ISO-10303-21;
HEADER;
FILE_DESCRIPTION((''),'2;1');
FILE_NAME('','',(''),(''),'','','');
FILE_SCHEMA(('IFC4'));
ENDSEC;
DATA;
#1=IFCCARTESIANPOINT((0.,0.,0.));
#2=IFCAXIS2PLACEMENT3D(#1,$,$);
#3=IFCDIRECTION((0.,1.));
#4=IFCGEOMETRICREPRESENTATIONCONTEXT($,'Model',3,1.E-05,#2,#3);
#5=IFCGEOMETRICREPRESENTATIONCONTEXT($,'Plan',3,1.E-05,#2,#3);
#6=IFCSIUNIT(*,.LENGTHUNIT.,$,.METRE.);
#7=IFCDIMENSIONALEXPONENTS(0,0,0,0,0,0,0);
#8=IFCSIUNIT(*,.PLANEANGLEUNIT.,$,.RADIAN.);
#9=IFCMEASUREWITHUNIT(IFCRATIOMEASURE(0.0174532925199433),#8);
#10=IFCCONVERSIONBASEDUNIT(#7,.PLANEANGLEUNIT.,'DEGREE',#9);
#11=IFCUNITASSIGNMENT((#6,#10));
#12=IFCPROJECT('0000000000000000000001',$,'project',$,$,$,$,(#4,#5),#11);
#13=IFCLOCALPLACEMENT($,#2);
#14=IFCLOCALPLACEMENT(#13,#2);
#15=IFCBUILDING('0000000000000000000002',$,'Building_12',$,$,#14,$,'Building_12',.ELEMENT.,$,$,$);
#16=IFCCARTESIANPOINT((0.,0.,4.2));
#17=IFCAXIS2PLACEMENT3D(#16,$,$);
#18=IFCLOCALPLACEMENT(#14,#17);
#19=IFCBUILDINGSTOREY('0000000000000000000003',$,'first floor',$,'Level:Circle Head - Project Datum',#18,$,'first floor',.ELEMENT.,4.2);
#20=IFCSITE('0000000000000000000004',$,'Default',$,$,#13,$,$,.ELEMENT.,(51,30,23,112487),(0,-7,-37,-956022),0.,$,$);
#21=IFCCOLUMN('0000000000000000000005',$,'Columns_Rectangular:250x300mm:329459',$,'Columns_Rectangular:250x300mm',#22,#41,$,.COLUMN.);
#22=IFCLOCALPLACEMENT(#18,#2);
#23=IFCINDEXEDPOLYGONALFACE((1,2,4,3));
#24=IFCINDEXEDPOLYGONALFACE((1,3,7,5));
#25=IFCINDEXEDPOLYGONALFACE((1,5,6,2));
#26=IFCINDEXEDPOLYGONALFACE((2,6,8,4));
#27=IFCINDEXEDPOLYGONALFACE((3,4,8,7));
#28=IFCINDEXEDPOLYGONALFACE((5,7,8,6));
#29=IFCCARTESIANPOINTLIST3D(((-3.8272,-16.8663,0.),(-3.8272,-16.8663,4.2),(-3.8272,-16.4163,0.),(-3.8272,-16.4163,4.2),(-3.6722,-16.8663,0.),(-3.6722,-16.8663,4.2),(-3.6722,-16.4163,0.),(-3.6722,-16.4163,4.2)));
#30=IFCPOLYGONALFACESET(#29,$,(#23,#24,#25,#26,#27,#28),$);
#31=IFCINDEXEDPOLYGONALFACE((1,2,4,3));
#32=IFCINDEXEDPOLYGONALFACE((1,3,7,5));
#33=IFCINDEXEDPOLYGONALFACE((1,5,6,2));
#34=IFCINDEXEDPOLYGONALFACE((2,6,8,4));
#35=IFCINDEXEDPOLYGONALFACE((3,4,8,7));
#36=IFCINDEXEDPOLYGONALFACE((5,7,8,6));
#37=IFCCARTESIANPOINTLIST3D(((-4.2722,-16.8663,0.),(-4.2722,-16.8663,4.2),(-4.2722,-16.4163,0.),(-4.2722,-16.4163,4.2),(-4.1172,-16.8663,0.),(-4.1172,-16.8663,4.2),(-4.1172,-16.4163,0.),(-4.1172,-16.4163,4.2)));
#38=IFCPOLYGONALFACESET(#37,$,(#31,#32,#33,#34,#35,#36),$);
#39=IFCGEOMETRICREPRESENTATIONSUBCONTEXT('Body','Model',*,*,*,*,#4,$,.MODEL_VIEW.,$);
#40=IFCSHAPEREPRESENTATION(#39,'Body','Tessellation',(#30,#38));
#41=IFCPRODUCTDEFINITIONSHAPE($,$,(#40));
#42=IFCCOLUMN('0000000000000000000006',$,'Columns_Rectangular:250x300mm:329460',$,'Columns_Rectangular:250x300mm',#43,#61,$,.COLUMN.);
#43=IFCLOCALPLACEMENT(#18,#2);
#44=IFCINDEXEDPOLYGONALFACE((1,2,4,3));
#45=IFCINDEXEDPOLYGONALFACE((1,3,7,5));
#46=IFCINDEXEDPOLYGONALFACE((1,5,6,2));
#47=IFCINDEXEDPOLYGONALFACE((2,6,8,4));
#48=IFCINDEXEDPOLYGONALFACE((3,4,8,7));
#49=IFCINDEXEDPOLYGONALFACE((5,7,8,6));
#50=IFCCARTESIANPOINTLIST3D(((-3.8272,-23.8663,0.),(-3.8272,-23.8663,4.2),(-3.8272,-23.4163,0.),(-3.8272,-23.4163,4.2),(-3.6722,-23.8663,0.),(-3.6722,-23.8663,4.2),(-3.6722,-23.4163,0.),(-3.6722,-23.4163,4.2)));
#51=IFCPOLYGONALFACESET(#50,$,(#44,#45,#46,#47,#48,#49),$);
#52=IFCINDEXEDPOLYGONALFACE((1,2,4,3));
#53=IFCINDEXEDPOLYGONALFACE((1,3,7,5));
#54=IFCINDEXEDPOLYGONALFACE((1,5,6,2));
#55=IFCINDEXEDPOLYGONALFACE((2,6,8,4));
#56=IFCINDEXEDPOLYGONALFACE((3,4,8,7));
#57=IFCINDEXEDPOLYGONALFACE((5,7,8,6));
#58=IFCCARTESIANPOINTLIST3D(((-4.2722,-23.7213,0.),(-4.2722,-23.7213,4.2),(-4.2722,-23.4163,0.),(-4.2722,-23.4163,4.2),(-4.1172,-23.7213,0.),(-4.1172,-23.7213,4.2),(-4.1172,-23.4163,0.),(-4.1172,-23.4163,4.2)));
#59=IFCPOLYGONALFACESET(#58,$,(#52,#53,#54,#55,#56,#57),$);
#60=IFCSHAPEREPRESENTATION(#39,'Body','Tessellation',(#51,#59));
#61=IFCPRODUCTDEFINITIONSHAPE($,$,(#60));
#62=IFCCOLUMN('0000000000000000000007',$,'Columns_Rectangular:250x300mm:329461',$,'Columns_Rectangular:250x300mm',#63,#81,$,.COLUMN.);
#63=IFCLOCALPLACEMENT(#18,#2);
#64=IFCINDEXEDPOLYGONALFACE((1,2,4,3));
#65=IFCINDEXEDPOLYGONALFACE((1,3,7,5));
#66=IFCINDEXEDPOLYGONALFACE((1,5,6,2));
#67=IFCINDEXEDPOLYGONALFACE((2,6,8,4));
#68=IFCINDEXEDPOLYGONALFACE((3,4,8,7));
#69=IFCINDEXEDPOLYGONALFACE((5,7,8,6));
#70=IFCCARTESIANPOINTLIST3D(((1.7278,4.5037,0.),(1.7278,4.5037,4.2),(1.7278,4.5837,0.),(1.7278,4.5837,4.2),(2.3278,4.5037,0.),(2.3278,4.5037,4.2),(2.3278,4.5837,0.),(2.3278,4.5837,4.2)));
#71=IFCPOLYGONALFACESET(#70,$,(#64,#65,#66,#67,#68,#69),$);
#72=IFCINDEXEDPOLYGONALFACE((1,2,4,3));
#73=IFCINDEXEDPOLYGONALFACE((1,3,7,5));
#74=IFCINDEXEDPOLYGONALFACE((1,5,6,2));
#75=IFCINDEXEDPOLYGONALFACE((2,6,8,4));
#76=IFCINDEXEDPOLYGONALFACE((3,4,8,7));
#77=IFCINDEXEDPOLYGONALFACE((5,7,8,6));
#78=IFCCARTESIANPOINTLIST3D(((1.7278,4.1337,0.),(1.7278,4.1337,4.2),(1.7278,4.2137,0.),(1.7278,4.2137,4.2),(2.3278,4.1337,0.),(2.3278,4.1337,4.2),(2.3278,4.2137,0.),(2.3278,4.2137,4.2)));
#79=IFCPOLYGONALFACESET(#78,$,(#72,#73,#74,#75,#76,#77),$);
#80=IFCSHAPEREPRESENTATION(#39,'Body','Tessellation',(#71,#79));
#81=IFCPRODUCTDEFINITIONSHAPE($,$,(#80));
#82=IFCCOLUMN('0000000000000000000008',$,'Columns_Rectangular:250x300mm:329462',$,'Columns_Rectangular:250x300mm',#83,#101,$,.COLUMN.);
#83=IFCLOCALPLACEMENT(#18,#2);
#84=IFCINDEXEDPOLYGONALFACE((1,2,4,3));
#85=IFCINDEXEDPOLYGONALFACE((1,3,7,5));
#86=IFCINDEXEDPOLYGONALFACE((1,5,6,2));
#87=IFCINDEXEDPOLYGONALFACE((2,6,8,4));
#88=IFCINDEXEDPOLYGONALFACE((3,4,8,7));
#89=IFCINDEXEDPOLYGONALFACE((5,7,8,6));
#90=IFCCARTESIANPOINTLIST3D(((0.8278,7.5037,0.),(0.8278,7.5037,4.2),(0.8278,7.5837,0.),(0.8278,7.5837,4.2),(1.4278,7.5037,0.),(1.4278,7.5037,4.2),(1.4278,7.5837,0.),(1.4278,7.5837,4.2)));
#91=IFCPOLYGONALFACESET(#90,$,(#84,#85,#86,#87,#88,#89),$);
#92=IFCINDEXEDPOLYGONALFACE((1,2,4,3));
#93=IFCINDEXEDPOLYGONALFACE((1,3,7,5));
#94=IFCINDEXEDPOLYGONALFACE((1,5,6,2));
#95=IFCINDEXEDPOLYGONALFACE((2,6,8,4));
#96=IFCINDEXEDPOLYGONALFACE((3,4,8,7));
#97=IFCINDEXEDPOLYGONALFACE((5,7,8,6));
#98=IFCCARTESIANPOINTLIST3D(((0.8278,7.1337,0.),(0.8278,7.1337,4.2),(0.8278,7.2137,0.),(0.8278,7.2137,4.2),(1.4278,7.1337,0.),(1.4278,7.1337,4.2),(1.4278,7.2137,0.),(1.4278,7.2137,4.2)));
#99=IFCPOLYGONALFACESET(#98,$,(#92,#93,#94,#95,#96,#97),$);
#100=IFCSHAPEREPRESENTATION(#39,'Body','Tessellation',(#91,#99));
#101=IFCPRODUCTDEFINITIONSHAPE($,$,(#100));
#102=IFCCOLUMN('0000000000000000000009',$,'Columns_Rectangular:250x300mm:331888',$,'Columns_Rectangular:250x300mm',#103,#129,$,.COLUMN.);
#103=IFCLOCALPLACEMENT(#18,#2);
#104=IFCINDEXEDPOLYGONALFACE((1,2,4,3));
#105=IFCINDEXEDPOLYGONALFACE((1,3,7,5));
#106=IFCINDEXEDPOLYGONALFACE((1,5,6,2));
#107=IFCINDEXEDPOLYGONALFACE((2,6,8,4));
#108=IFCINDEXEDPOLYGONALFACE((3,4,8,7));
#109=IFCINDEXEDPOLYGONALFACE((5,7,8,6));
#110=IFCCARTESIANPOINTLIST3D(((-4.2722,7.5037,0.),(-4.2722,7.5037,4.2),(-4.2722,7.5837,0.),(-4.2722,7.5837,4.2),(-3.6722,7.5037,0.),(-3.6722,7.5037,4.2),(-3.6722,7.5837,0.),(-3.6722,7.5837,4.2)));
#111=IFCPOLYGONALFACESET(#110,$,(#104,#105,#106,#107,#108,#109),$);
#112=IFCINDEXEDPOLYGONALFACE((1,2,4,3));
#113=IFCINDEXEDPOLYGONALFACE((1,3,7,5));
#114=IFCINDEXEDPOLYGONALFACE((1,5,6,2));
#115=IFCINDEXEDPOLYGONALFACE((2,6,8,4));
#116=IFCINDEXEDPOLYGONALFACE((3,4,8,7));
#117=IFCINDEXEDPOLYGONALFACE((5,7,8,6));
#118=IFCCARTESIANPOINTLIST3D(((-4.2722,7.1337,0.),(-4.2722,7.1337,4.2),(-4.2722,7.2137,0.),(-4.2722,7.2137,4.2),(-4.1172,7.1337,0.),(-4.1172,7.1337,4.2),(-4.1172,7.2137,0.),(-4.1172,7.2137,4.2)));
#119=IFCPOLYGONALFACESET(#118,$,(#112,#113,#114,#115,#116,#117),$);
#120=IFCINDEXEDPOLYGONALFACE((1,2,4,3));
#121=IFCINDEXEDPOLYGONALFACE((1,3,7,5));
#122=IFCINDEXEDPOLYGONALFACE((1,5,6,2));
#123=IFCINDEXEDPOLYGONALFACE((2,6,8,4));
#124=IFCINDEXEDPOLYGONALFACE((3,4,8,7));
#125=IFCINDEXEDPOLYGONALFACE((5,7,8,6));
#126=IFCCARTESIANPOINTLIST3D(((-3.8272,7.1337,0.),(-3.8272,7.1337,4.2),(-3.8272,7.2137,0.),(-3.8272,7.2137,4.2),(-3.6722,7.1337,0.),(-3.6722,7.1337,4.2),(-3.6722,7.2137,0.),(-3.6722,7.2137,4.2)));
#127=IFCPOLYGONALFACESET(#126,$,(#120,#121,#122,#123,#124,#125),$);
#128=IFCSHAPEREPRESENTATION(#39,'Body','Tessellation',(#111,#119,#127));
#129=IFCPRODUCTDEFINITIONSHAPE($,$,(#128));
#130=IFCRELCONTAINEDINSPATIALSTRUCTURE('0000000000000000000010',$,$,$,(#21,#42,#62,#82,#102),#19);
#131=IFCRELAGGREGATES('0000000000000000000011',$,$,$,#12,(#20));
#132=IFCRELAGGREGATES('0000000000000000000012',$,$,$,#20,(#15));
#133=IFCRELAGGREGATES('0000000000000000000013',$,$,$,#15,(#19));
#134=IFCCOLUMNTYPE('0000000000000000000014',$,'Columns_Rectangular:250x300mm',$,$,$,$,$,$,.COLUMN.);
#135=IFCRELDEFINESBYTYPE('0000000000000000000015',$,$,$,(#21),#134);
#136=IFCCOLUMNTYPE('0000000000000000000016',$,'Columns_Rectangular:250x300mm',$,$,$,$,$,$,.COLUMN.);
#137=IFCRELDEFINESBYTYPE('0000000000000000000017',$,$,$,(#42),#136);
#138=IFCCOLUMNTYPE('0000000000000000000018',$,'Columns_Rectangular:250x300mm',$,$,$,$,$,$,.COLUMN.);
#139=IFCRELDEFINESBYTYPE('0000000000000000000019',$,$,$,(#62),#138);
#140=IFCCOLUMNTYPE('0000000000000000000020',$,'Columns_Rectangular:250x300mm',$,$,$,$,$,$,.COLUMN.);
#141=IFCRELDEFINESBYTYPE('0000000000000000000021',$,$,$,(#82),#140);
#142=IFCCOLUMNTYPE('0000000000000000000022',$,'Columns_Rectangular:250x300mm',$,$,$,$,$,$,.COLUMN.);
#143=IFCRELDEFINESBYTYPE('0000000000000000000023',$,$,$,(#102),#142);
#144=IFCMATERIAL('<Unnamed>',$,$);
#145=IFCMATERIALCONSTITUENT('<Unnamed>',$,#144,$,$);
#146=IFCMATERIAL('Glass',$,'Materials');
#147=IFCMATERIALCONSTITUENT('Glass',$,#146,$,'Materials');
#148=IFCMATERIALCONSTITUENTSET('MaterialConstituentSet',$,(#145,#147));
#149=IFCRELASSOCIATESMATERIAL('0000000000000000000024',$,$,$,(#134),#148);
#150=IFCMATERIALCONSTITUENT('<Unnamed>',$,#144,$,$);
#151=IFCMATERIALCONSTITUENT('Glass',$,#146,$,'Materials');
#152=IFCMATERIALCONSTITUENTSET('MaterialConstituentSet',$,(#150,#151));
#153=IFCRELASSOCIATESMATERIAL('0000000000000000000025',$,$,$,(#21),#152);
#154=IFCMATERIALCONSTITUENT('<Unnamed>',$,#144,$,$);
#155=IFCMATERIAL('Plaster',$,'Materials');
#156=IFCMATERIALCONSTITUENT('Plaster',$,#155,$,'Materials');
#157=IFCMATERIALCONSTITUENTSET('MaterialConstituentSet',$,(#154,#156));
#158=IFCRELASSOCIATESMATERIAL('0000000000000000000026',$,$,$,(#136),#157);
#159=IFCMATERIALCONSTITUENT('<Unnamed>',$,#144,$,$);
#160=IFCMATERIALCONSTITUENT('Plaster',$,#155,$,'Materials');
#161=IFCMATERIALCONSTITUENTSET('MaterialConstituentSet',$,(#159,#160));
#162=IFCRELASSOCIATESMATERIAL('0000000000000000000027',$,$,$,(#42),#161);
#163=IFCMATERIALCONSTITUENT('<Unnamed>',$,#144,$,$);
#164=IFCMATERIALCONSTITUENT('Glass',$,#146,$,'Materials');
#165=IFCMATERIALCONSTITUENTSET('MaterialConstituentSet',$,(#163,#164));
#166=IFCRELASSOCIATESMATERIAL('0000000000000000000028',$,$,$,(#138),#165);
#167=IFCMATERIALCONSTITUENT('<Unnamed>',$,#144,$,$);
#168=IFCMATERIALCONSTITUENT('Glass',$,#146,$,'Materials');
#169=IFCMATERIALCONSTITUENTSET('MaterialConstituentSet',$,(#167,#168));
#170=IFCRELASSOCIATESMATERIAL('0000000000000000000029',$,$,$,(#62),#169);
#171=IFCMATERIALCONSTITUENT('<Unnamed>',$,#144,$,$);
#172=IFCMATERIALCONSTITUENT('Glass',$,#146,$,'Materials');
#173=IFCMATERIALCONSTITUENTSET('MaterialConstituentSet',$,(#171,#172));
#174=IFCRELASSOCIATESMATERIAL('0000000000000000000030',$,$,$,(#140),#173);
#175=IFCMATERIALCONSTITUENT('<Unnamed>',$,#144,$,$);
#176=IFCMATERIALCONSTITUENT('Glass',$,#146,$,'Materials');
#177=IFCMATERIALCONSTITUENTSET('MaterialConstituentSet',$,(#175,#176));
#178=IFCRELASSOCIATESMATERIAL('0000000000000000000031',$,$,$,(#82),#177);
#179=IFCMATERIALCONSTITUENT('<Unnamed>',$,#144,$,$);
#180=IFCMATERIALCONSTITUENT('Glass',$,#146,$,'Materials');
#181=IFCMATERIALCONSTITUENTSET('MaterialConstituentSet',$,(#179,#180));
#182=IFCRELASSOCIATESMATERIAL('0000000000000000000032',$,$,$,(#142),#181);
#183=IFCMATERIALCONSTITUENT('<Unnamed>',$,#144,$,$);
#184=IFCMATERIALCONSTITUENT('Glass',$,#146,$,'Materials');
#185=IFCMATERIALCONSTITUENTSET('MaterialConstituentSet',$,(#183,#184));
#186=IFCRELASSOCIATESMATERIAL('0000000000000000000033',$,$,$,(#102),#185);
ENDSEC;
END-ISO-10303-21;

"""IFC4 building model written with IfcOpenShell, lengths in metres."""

from ifc_helpers import new_model, entity, si_unit, converted_unit, direction, frame, origin, place, context, subcontext, project, spatial, indexed_curve, outline, extrude, source, transform, mapped, material, constituent, constituent_set, type_object, type_shapes, element, save


model = new_model("IFC4")

# Units and contexts
model_context = context("Model", 3, precision=1e-05, world=origin(), true_north=direction((0.0, 1.0)))
plan_context = context("Plan", 3, precision=1e-05, world=origin(), true_north=direction((0.0, 1.0)))
body_context = subcontext(model_context, "Body", "Model", "MODEL_VIEW")
ifc_project = project(units=[si_unit("LENGTHUNIT", "METRE"), converted_unit("PLANEANGLEUNIT", "DEGREE", entity("IfcRatioMeasure", 0.0174532925199433), si_unit("PLANEANGLEUNIT", "RADIAN"), dimensions=[0, 0, 0, 0, 0, 0, 0])], contexts=[model_context, plan_context])

# Site, building, storey
site_placement = place(None, origin())
site = spatial("IfcSite", under=ifc_project, at=site_placement, Name="Default", CompositionType="ELEMENT", RefLatitude=(51, 30, 23, 112487), RefLongitude=(0, -7, -37, -956022), RefElevation=0.0)
building_placement = place(site_placement, origin())
building = spatial("IfcBuilding", under=site, at=building_placement, Name="Building_12", LongName="Building_12", CompositionType="ELEMENT")
storey_placement = place(building_placement, frame((0.0, 0.0, 4.2)))
storey = spatial("IfcBuildingStorey", under=building, at=storey_placement, Name="first floor", ObjectType="Level:Circle Head - Project Datum", LongName="first floor", CompositionType="ELEMENT", Elevation=4.2)

# Columns
ifc_material_1 = material(Name="<Unnamed>")
ifc_material_2 = material(Name="Plaster", Category="Materials")
ifc_material_3 = material(Name="Glass", Category="Materials")
ifc_constituent_1 = constituent(ifc_material_1, Name="<Unnamed>")
ifc_constituent_2 = constituent(ifc_material_3, Name="Glass", Category="Materials")
ifc_constituent_set_1 = constituent_set(constituents=[ifc_constituent_1, ifc_constituent_2], Name="MaterialConstituentSet")
ifc_constituent_3 = constituent(ifc_material_1, Name="<Unnamed>")
ifc_constituent_4 = constituent(ifc_material_3, Name="Glass", Category="Materials")
ifc_constituent_set_2 = constituent_set(constituents=[ifc_constituent_3, ifc_constituent_4], Name="MaterialConstituentSet")
column_type_1 = type_object("IfcColumnType", Name="Columns_Rectangular:250x300mm", PredefinedType="COLUMN", material=ifc_constituent_set_2)
shared_shape_1 = source(origin(), body_context, "Body", "SweptSolid", [
    extrude(outline(indexed_curve([(-0.225, -0.0775), (0.225, -0.0775), (0.225, 0.0775), (-0.225, 0.0775), (-0.225, -0.0775)], self_intersect=False)), frame((-3.7497, -16.6413, 4.2), z_axis=(0.0, 0.0, 1.0), x_axis=(0.0, -1.0, 0.0)), (0.0, 0.0, 1.0), 4.2),
    extrude(outline(indexed_curve([(-0.225, -0.0775), (0.225, -0.0775), (0.225, 0.0775), (-0.225, 0.0775), (-0.225, -0.0775)], self_intersect=False)), frame((-4.1947, -16.6413, 4.2), z_axis=(0.0, 0.0, 1.0), x_axis=(0.0, -1.0, 0.0)), (0.0, 0.0, 1.0), 4.2),
])
type_shapes(column_type_1, [shared_shape_1])
column_1_placement = place(storey_placement, frame((0.0, 0.0, -4.2)))
element("IfcColumn", 1, at=column_1_placement, inside=storey, type_object=column_type_1, material=ifc_constituent_set_1, Name="Columns_Rectangular:250x300mm:329459", ObjectType="Columns_Rectangular:250x300mm", PredefinedType="COLUMN", context=body_context, shape_type="MappedRepresentation", body=[
    mapped(shared_shape_1, transform((0.0, 0.0, 0.0), scale=1.0)),
])
ifc_constituent_5 = constituent(ifc_material_1, Name="<Unnamed>")
ifc_constituent_6 = constituent(ifc_material_2, Name="Plaster", Category="Materials")
ifc_constituent_set_3 = constituent_set(constituents=[ifc_constituent_5, ifc_constituent_6], Name="MaterialConstituentSet")
ifc_constituent_7 = constituent(ifc_material_1, Name="<Unnamed>")
ifc_constituent_8 = constituent(ifc_material_2, Name="Plaster", Category="Materials")
ifc_constituent_set_4 = constituent_set(constituents=[ifc_constituent_7, ifc_constituent_8], Name="MaterialConstituentSet")
column_type_2 = type_object("IfcColumnType", Name="Columns_Rectangular:250x300mm", PredefinedType="COLUMN", material=ifc_constituent_set_4)
shared_shape_2 = source(origin(), body_context, "Body", "SweptSolid", [
    extrude(outline(indexed_curve([(-0.225, -0.0775), (0.225, -0.0775), (0.225, 0.0775), (-0.225, 0.0775), (-0.225, -0.0775)], self_intersect=False)), frame((-3.7497, -23.6413, 4.2), z_axis=(0.0, 0.0, 1.0), x_axis=(0.0, -1.0, 0.0)), (0.0, 0.0, 1.0), 4.2),
    extrude(outline(indexed_curve([(-0.1525, -0.0775), (0.1525, -0.0775), (0.1525, 0.0775), (-0.1525, 0.0775), (-0.1525, -0.0775)], self_intersect=False)), frame((-4.1947, -23.5688, 4.2), z_axis=(0.0, 0.0, 1.0), x_axis=(0.0, -1.0, 0.0)), (0.0, 0.0, 1.0), 4.2),
])
type_shapes(column_type_2, [shared_shape_2])
column_2_placement = place(storey_placement, frame((0.0, 0.0, -4.2)))
element("IfcColumn", 2, at=column_2_placement, inside=storey, type_object=column_type_2, material=ifc_constituent_set_3, Name="Columns_Rectangular:250x300mm:329460", ObjectType="Columns_Rectangular:250x300mm", PredefinedType="COLUMN", context=body_context, shape_type="MappedRepresentation", body=[
    mapped(shared_shape_2, transform((0.0, 0.0, 0.0), scale=1.0)),
])
ifc_constituent_9 = constituent(ifc_material_1, Name="<Unnamed>")
ifc_constituent_10 = constituent(ifc_material_3, Name="Glass", Category="Materials")
ifc_constituent_set_5 = constituent_set(constituents=[ifc_constituent_9, ifc_constituent_10], Name="MaterialConstituentSet")
ifc_constituent_11 = constituent(ifc_material_1, Name="<Unnamed>")
ifc_constituent_12 = constituent(ifc_material_3, Name="Glass", Category="Materials")
ifc_constituent_set_6 = constituent_set(constituents=[ifc_constituent_11, ifc_constituent_12], Name="MaterialConstituentSet")
column_type_3 = type_object("IfcColumnType", Name="Columns_Rectangular:250x300mm", PredefinedType="COLUMN", material=ifc_constituent_set_6)
shared_shape_3 = source(origin(), body_context, "Body", "SweptSolid", [
    extrude(outline(indexed_curve([(-0.04, -0.3), (0.04, -0.3), (0.04, 0.3), (-0.04, 0.3), (-0.04, -0.3)], self_intersect=False)), frame((2.0278, 4.5437, 4.2), z_axis=(0.0, 0.0, 1.0), x_axis=(0.0, -1.0, 0.0)), (0.0, 0.0, 1.0), 4.2),
    extrude(outline(indexed_curve([(-0.04, -0.3), (0.04, -0.3), (0.04, 0.3), (-0.04, 0.3), (-0.04, -0.3)], self_intersect=False)), frame((2.0278, 4.1737, 4.2), z_axis=(0.0, 0.0, 1.0), x_axis=(0.0, -1.0, 0.0)), (0.0, 0.0, 1.0), 4.2),
])
type_shapes(column_type_3, [shared_shape_3])
column_3_placement = place(storey_placement, frame((0.0, 0.0, -4.2)))
element("IfcColumn", 3, at=column_3_placement, inside=storey, type_object=column_type_3, material=ifc_constituent_set_5, Name="Columns_Rectangular:250x300mm:329461", ObjectType="Columns_Rectangular:250x300mm", PredefinedType="COLUMN", context=body_context, shape_type="MappedRepresentation", body=[
    mapped(shared_shape_3, transform((0.0, 0.0, 0.0), scale=1.0)),
])
ifc_constituent_13 = constituent(ifc_material_1, Name="<Unnamed>")
ifc_constituent_14 = constituent(ifc_material_3, Name="Glass", Category="Materials")
ifc_constituent_set_7 = constituent_set(constituents=[ifc_constituent_13, ifc_constituent_14], Name="MaterialConstituentSet")
ifc_constituent_15 = constituent(ifc_material_1, Name="<Unnamed>")
ifc_constituent_16 = constituent(ifc_material_3, Name="Glass", Category="Materials")
ifc_constituent_set_8 = constituent_set(constituents=[ifc_constituent_15, ifc_constituent_16], Name="MaterialConstituentSet")
column_type_4 = type_object("IfcColumnType", Name="Columns_Rectangular:250x300mm", PredefinedType="COLUMN", material=ifc_constituent_set_8)
shared_shape_4 = source(origin(), body_context, "Body", "SweptSolid", [
    extrude(outline(indexed_curve([(-0.04, -0.3), (0.04, -0.3), (0.04, 0.3), (-0.04, 0.3), (-0.04, -0.3)], self_intersect=False)), frame((1.1278, 7.5437, 4.2), z_axis=(0.0, 0.0, 1.0), x_axis=(0.0, -1.0, 0.0)), (0.0, 0.0, 1.0), 4.2),
    extrude(outline(indexed_curve([(-0.04, -0.3), (0.04, -0.3), (0.04, 0.3), (-0.04, 0.3), (-0.04, -0.3)], self_intersect=False)), frame((1.1278, 7.1737, 4.2), z_axis=(0.0, 0.0, 1.0), x_axis=(0.0, -1.0, 0.0)), (0.0, 0.0, 1.0), 4.2),
])
type_shapes(column_type_4, [shared_shape_4])
column_4_placement = place(storey_placement, frame((0.0, 0.0, -4.2)))
element("IfcColumn", 4, at=column_4_placement, inside=storey, type_object=column_type_4, material=ifc_constituent_set_7, Name="Columns_Rectangular:250x300mm:329462", ObjectType="Columns_Rectangular:250x300mm", PredefinedType="COLUMN", context=body_context, shape_type="MappedRepresentation", body=[
    mapped(shared_shape_4, transform((0.0, 0.0, 0.0), scale=1.0)),
])
ifc_constituent_17 = constituent(ifc_material_1, Name="<Unnamed>")
ifc_constituent_18 = constituent(ifc_material_3, Name="Glass", Category="Materials")
ifc_constituent_set_9 = constituent_set(constituents=[ifc_constituent_17, ifc_constituent_18], Name="MaterialConstituentSet")
ifc_constituent_19 = constituent(ifc_material_1, Name="<Unnamed>")
ifc_constituent_20 = constituent(ifc_material_3, Name="Glass", Category="Materials")
ifc_constituent_set_10 = constituent_set(constituents=[ifc_constituent_19, ifc_constituent_20], Name="MaterialConstituentSet")
column_type_5 = type_object("IfcColumnType", Name="Columns_Rectangular:250x300mm", PredefinedType="COLUMN", material=ifc_constituent_set_10)
shared_shape_5 = source(origin(), body_context, "Body", "SweptSolid", [
    extrude(outline(indexed_curve([(-0.04, -0.3), (0.04, -0.3), (0.04, 0.3), (-0.04, 0.3), (-0.04, -0.3)], self_intersect=False)), frame((-3.9722, 7.5437, 4.2), z_axis=(0.0, 0.0, 1.0), x_axis=(0.0, -1.0, 0.0)), (0.0, 0.0, 1.0), 4.2),
    extrude(outline(indexed_curve([(-0.04, -0.0775), (0.04, -0.0775), (0.04, 0.0775), (-0.04, 0.0775), (-0.04, -0.0775)], self_intersect=False)), frame((-4.1947, 7.1737, 4.2), z_axis=(0.0, 0.0, 1.0), x_axis=(0.0, -1.0, 0.0)), (0.0, 0.0, 1.0), 4.2),
    extrude(outline(indexed_curve([(-0.04, -0.0775), (0.04, -0.0775), (0.04, 0.0775), (-0.04, 0.0775), (-0.04, -0.0775)], self_intersect=False)), frame((-3.7497, 7.1737, 4.2), z_axis=(0.0, 0.0, 1.0), x_axis=(0.0, -1.0, 0.0)), (0.0, 0.0, 1.0), 4.2),
])
type_shapes(column_type_5, [shared_shape_5])
column_5_placement = place(storey_placement, frame((0.0, 0.0, -4.2)))
element("IfcColumn", 5, at=column_5_placement, inside=storey, type_object=column_type_5, material=ifc_constituent_set_9, Name="Columns_Rectangular:250x300mm:331888", ObjectType="Columns_Rectangular:250x300mm", PredefinedType="COLUMN", context=body_context, shape_type="MappedRepresentation", body=[
    mapped(shared_shape_5, transform((0.0, 0.0, 0.0), scale=1.0)),
])

save(model, "model.ifc")
